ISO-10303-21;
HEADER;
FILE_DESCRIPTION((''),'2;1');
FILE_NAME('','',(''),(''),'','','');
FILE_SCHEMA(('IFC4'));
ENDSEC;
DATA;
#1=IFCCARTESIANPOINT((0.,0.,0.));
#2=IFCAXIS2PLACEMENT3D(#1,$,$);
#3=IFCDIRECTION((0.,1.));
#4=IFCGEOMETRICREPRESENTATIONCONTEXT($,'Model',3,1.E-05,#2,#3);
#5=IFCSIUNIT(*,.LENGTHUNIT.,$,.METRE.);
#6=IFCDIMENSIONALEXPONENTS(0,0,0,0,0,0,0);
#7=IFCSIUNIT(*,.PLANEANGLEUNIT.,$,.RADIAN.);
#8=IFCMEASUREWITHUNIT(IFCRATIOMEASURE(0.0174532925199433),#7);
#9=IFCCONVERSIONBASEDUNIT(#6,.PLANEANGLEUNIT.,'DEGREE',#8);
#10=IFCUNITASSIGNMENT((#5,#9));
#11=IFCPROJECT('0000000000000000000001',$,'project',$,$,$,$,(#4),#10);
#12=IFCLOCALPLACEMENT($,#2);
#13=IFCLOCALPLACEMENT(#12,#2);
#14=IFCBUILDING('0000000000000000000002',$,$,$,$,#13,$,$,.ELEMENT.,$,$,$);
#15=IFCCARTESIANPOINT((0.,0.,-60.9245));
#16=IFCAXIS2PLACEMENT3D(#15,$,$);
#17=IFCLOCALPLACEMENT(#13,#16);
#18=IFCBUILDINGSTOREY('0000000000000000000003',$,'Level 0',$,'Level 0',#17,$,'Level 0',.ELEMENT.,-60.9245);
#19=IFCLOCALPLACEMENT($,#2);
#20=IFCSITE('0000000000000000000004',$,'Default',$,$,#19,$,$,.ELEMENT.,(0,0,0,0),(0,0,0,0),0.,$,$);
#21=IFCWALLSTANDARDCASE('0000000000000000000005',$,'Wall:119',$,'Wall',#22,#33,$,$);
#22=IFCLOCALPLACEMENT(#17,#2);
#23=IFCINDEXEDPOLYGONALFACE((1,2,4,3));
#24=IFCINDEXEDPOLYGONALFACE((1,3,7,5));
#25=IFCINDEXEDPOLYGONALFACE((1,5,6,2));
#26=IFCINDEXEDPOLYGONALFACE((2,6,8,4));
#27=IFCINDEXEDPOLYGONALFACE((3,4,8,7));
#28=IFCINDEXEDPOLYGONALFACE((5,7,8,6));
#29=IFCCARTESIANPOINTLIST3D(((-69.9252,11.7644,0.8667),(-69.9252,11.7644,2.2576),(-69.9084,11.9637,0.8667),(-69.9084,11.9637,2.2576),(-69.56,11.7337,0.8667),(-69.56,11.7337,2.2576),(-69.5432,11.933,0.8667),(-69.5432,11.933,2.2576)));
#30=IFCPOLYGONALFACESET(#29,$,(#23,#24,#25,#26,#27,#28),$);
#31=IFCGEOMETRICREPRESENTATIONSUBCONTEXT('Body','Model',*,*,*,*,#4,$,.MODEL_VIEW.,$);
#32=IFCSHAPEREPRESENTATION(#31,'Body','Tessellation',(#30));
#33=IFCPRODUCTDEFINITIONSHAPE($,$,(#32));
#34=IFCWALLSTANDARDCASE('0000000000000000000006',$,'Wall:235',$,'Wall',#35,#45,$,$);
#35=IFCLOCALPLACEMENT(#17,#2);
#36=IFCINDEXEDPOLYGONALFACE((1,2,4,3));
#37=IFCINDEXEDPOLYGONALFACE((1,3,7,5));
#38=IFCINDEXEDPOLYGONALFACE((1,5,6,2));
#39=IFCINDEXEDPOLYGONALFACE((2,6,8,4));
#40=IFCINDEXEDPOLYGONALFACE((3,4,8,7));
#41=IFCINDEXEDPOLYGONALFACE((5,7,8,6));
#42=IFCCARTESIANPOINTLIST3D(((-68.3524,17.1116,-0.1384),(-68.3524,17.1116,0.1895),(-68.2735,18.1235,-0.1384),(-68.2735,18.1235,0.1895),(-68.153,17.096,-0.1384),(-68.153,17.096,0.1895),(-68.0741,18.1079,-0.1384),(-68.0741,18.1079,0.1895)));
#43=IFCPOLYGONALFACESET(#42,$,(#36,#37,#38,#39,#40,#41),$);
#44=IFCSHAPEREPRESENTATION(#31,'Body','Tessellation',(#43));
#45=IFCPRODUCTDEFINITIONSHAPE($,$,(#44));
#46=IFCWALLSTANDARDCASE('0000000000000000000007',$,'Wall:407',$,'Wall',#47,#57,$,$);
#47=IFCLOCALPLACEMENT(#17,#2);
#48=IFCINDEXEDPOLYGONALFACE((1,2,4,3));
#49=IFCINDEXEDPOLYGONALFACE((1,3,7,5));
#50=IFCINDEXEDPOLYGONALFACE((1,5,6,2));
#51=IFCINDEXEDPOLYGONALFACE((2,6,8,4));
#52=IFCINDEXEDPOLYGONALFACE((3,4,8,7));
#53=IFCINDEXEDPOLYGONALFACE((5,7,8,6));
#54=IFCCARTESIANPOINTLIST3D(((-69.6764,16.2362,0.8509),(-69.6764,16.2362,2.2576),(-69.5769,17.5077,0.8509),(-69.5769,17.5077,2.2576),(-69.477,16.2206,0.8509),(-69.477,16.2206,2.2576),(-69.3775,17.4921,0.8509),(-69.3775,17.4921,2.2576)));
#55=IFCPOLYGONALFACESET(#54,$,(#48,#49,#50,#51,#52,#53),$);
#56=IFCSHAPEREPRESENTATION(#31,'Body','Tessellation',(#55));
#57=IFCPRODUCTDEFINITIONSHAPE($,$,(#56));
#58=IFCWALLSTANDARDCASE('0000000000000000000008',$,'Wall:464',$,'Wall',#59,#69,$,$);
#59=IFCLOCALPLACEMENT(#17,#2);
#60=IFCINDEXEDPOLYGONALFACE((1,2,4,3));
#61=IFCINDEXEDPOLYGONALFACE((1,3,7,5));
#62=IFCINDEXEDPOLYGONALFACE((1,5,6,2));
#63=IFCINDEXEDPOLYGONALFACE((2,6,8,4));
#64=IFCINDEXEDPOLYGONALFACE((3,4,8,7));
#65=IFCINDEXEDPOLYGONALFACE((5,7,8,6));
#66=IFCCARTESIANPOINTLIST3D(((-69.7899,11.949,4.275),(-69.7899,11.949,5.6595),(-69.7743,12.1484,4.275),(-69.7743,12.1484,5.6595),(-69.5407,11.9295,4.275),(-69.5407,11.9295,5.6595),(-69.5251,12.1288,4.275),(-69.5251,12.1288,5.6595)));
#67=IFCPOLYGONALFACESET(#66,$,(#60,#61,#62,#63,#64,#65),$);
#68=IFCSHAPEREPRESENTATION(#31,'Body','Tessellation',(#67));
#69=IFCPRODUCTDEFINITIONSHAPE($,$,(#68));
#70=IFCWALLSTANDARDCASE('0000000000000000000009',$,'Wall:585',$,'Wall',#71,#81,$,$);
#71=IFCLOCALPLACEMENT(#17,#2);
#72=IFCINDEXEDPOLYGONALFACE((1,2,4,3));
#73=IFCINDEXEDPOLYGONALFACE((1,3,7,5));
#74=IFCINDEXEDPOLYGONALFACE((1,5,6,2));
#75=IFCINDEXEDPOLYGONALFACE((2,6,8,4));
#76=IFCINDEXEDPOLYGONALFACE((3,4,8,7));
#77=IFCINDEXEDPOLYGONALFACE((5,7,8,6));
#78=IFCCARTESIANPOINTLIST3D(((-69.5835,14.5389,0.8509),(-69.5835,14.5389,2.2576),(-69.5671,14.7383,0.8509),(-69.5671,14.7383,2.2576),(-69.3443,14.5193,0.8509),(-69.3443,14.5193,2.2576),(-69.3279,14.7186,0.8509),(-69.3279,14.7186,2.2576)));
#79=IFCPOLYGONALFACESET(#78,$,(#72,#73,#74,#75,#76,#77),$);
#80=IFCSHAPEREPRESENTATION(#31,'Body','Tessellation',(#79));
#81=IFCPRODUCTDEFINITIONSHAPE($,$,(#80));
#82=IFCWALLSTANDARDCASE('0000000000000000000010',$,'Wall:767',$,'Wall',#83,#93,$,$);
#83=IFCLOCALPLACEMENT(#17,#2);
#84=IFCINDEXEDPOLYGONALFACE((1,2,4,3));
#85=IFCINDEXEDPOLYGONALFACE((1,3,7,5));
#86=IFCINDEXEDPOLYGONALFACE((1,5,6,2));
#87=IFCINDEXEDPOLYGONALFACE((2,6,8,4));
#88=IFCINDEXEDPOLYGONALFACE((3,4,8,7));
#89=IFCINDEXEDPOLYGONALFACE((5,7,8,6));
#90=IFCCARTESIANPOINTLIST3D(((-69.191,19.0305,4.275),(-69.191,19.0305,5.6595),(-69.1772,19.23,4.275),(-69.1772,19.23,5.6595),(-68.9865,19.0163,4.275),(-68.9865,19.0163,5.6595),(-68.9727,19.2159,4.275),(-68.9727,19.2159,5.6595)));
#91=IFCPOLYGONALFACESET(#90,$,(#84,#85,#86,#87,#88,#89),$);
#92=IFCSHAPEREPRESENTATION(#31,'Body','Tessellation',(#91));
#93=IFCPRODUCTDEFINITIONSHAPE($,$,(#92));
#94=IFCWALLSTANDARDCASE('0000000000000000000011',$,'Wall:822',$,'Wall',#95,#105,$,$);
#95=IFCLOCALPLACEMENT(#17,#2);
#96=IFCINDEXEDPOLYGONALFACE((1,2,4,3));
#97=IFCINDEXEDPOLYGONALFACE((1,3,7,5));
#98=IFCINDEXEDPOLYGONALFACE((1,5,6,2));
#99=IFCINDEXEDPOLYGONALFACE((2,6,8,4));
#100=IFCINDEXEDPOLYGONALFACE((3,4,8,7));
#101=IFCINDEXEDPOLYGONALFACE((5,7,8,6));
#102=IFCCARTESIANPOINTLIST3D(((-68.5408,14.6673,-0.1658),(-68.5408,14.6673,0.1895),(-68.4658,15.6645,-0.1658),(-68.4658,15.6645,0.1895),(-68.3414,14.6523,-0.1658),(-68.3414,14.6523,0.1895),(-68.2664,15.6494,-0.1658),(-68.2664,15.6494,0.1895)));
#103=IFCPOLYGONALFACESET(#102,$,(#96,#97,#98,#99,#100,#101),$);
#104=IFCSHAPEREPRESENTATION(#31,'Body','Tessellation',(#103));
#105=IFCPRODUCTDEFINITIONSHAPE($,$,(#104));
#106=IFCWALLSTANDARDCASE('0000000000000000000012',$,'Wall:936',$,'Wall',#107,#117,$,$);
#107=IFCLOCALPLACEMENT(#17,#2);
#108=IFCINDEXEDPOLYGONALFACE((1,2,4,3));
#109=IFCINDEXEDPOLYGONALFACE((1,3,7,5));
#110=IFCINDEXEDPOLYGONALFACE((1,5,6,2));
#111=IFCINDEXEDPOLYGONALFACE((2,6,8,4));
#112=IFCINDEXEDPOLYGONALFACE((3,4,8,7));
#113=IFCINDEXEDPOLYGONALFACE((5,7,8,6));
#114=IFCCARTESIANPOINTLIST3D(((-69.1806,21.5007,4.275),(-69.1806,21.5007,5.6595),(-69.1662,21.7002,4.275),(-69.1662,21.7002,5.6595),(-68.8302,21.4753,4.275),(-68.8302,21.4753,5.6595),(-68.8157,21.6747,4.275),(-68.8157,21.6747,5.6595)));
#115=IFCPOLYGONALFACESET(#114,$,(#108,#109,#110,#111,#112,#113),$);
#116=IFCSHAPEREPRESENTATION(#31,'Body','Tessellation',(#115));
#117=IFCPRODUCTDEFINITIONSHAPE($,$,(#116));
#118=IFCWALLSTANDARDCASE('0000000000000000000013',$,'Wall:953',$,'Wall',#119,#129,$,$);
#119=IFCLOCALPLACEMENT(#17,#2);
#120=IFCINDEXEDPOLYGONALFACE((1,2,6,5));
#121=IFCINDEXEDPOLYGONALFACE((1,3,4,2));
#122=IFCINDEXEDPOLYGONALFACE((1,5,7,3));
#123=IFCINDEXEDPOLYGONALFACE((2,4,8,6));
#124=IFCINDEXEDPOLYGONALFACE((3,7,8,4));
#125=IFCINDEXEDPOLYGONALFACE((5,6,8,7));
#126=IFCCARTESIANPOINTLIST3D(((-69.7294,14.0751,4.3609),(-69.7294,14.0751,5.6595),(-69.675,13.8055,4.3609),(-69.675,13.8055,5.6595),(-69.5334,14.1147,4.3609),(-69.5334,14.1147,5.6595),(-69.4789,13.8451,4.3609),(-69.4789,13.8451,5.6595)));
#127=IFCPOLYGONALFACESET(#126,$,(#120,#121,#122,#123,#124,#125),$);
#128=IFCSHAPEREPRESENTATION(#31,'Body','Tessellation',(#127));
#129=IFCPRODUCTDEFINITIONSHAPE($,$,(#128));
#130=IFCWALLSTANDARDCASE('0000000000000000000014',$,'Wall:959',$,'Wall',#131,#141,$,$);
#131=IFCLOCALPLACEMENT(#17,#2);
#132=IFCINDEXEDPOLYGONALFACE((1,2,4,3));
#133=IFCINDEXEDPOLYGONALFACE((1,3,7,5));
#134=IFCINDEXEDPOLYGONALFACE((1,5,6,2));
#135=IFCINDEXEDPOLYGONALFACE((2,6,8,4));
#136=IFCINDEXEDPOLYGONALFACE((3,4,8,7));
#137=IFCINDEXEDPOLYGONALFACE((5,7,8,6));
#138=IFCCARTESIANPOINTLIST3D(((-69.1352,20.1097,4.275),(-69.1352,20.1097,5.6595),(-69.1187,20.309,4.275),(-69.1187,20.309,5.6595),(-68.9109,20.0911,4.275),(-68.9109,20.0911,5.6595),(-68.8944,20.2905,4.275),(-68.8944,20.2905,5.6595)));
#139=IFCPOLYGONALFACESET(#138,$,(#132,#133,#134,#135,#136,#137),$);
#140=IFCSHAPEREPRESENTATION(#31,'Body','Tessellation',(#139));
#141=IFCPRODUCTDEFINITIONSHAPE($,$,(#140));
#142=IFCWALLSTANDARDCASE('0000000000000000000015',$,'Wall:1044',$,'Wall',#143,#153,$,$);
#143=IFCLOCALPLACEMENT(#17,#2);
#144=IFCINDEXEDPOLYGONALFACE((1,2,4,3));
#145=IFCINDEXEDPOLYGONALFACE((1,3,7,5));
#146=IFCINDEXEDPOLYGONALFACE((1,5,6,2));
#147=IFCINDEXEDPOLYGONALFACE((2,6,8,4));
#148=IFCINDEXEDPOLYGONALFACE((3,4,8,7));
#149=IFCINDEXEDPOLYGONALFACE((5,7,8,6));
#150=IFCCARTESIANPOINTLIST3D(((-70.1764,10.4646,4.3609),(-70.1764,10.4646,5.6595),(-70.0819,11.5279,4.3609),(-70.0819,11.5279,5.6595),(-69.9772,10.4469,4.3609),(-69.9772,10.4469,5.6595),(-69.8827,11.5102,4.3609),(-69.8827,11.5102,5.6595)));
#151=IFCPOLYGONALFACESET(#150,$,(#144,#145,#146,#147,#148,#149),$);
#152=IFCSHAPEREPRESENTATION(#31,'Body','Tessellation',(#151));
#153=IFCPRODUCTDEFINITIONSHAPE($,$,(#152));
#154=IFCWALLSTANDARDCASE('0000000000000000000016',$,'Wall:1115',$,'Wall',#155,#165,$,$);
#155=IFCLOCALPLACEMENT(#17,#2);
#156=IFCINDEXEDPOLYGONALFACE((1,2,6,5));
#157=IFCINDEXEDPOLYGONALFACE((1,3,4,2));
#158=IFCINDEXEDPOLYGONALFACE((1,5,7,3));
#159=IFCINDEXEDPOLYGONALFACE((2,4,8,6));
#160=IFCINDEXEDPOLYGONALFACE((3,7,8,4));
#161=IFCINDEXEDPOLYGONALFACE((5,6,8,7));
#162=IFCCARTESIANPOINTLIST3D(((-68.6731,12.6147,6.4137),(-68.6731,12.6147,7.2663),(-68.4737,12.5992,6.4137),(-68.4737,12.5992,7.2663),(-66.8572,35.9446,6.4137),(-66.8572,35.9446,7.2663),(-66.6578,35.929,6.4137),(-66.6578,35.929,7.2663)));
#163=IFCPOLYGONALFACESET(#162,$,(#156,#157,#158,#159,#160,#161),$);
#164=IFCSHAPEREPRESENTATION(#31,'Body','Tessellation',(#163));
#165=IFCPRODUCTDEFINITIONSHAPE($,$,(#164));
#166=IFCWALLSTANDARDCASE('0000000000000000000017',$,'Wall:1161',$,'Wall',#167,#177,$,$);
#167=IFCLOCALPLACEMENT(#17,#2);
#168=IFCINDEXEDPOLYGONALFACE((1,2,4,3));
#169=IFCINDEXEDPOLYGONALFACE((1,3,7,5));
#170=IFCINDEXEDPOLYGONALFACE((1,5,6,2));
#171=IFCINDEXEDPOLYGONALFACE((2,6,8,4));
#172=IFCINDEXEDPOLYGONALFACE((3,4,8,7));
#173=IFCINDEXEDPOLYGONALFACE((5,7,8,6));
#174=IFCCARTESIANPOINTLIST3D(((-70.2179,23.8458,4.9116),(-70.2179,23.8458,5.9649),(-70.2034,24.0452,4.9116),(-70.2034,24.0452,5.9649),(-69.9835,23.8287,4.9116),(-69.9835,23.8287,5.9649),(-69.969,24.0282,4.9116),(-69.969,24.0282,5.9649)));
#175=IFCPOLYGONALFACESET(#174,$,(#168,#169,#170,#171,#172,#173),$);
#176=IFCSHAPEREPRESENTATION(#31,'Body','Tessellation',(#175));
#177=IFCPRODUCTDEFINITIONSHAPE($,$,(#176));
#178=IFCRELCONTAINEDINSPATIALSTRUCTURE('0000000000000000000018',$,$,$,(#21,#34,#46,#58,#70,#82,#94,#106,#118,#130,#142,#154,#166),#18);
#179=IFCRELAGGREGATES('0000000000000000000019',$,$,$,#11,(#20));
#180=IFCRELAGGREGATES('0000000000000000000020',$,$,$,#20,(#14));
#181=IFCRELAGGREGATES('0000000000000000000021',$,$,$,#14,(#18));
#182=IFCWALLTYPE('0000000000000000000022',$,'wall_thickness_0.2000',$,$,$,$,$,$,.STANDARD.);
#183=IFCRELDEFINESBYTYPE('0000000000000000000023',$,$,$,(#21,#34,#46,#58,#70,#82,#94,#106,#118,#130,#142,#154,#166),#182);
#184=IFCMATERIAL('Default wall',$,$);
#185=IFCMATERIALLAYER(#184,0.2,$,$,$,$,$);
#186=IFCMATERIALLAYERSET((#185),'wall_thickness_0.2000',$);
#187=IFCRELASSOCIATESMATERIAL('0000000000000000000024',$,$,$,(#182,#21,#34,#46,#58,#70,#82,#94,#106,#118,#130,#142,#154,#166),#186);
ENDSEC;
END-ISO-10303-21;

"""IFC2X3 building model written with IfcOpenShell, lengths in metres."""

from ifc_helpers import new_model, entity, si_unit, converted_unit, direction, frame, origin, place, context, subcontext, project, spatial, polyline, outline, extrude, material, layer, layer_set, layer_usage, type_object, element, save


model = new_model("IFC2X3")

# Units and contexts
model_context = context("Model", 3, precision=1e-05, world=origin(), true_north=direction((0.0, 1.0)))
body_context = subcontext(model_context, "Body", "Model", "MODEL_VIEW")
ifc_project = project(units=[si_unit("LENGTHUNIT", "METRE"), converted_unit("PLANEANGLEUNIT", "DEGREE", entity("IfcRatioMeasure", 0.0174532925199433), si_unit("PLANEANGLEUNIT", "RADIAN"), dimensions=[0, 0, 0, 0, 0, 0, 0])], contexts=[model_context])

# Site, building, storey
site_placement = place(None, origin())
site = spatial("IfcSite", under=ifc_project, at=site_placement, Name="Default", CompositionType="ELEMENT", RefLatitude=(0, 0, 0, 0), RefLongitude=(0, 0, 0, 0), RefElevation=0.0)
placement_1 = place(None, origin())
building_placement = place(placement_1, origin())
building = spatial("IfcBuilding", under=site, at=building_placement, CompositionType="ELEMENT")
storey_placement = place(building_placement, frame((0.0, 0.0, -60.9245)))
storey = spatial("IfcBuildingStorey", under=building, at=storey_placement, Name="Level 0", ObjectType="Level 0", LongName="Level 0", CompositionType="ELEMENT", Elevation=-60.9245)

# Walls
ifc_material = material(Name="Default wall")
ifc_layer = layer(ifc_material, 0.2)
ifc_layer_set = layer_set([ifc_layer], Name="wall_thickness_0.2000")
ifc_layer_usage = layer_usage(ifc_layer_set, "AXIS2", "POSITIVE", -0.1)
wall_type = type_object("IfcWallType", Name="wall_thickness_0.2000", PredefinedType="STANDARD", material=ifc_layer_set)
placement_2 = place(building_placement, frame((0.0, 0.0, -60.0578)))
wall_1_placement = place(placement_2, frame((-69.5516, 11.8333, 0.0), z_axis=(0.0, 0.0, 1.0), x_axis=(-0.996479, 0.083848, 0.0)))
element("IfcWallStandardCase", 1, at=wall_1_placement, inside=storey, type_object=wall_type, material=ifc_layer_usage, Name="Wall:119", ObjectType="Wall", context=body_context, shape_type="SweptSolid", body=[
    extrude(outline(polyline([(0.3665, -0.1), (0.3665, 0.1), (0.0, 0.1), (0.0, -0.1), (0.3665, -0.1)])), origin(), (0.0, 0.0, 1.0), 1.3909),
])
placement_3 = place(building_placement, frame((0.0, 0.0, -61.0629)))
wall_2_placement = place(placement_3, frame((-68.2527, 17.1038, 0.0), z_axis=(0.0, 0.0, 1.0), x_axis=(0.077737, 0.996974, 0.0)))
element("IfcWallStandardCase", 2, at=wall_2_placement, inside=storey, type_object=wall_type, material=ifc_layer_usage, Name="Wall:235", ObjectType="Wall", context=body_context, shape_type="SweptSolid", body=[
    extrude(outline(polyline([(1.015, -0.1), (1.015, 0.1), (0.0, 0.1), (0.0, -0.1), (1.015, -0.1)])), origin(), (0.0, 0.0, 1.0), 0.3279),
])
placement_4 = place(building_placement, frame((0.0, 0.0, -60.0736)))
wall_3_placement = place(placement_4, frame((-69.4772, 17.4999, 0.0), z_axis=(0.0, 0.0, 1.0), x_axis=(-0.078009, -0.996953, 0.0)))
element("IfcWallStandardCase", 3, at=wall_3_placement, inside=storey, type_object=wall_type, material=ifc_layer_usage, Name="Wall:407", ObjectType="Wall", context=body_context, shape_type="SweptSolid", body=[
    extrude(outline(polyline([(1.2754, -0.1), (1.2754, 0.1), (0.0, 0.1), (0.0, -0.1), (1.2754, -0.1)])), origin(), (0.0, 0.0, 1.0), 1.4068),
])
placement_5 = place(building_placement, frame((0.0, 0.0, -56.6495)))
wall_4_placement = place(placement_5, frame((-69.5329, 12.0291, 0.0), z_axis=(0.0, 0.0, 1.0), x_axis=(-0.996945, 0.078106, 0.0)))
element("IfcWallStandardCase", 4, at=wall_4_placement, inside=storey, type_object=wall_type, material=ifc_layer_usage, Name="Wall:464", ObjectType="Wall", context=body_context, shape_type="SweptSolid", body=[
    extrude(outline(polyline([(0.25, -0.1), (0.25, 0.1), (0.0, 0.1), (0.0, -0.1), (0.25, -0.1)])), origin(), (0.0, 0.0, 1.0), 1.3845),
])
placement_6 = place(building_placement, frame((0.0, 0.0, -60.0736)))
wall_5_placement = place(placement_6, frame((-69.3361, 14.6189, 0.0), z_axis=(0.0, 0.0, 1.0), x_axis=(-0.996635, 0.081969, 0.0)))
element("IfcWallStandardCase", 5, at=wall_5_placement, inside=storey, type_object=wall_type, material=ifc_layer_usage, Name="Wall:585", ObjectType="Wall", context=body_context, shape_type="SweptSolid", body=[
    extrude(outline(polyline([(0.24, -0.1), (0.24, 0.1), (0.0, 0.1), (0.0, -0.1), (0.24, -0.1)])), origin(), (0.0, 0.0, 1.0), 1.4068),
])
placement_7 = place(building_placement, frame((0.0, 0.0, -56.6495)))
wall_6_placement = place(placement_7, frame((-68.9796, 19.1161, 0.0), z_axis=(0.0, 0.0, 1.0), x_axis=(-0.997624, 0.068897, 0.0)))
element("IfcWallStandardCase", 6, at=wall_6_placement, inside=storey, type_object=wall_type, material=ifc_layer_usage, Name="Wall:767", ObjectType="Wall", context=body_context, shape_type="SweptSolid", body=[
    extrude(outline(polyline([(0.205, -0.1), (0.205, 0.1), (0.0, 0.1), (0.0, -0.1), (0.205, -0.1)])), origin(), (0.0, 0.0, 1.0), 1.3845),
])
placement_8 = place(building_placement, frame((0.0, 0.0, -61.0903)))
wall_7_placement = place(placement_8, frame((-68.4411, 14.6598, 0.0), z_axis=(0.0, 0.0, 1.0), x_axis=(0.075028, 0.997181, 0.0)))
element("IfcWallStandardCase", 7, at=wall_7_placement, inside=storey, type_object=wall_type, material=ifc_layer_usage, Name="Wall:822", ObjectType="Wall", context=body_context, shape_type="SweptSolid", body=[
    extrude(outline(polyline([(1.0, -0.1), (1.0, 0.1), (0.0, 0.1), (0.0, -0.1), (1.0, -0.1)])), origin(), (0.0, 0.0, 1.0), 0.3553),
])
placement_9 = place(building_placement, frame((0.0, 0.0, -56.6495)))
wall_8_placement = place(placement_9, frame((-68.8229, 21.575, 0.0), z_axis=(0.0, 0.0, 1.0), x_axis=(-0.997378, 0.072361, 0.0)))
element("IfcWallStandardCase", 8, at=wall_8_placement, inside=storey, type_object=wall_type, material=ifc_layer_usage, Name="Wall:936", ObjectType="Wall", context=body_context, shape_type="SweptSolid", body=[
    extrude(outline(polyline([(0.3514, -0.1), (0.3514, 0.1), (0.0, 0.1), (0.0, -0.1), (0.3514, -0.1)])), origin(), (0.0, 0.0, 1.0), 1.3845),
])
placement_10 = place(building_placement, frame((0.0, 0.0, -56.5636)))
wall_9_placement = place(placement_10, frame((-69.5769, 13.8253, 0.0), z_axis=(0.0, 0.0, 1.0), x_axis=(-0.197976, 0.980207, 0.0)))
element("IfcWallStandardCase", 9, at=wall_9_placement, inside=storey, type_object=wall_type, material=ifc_layer_usage, Name="Wall:953", ObjectType="Wall", context=body_context, shape_type="SweptSolid", body=[
    extrude(outline(polyline([(0.275, -0.1), (0.275, 0.1), (0.0, 0.1), (0.0, -0.1), (0.275, -0.1)])), origin(), (0.0, 0.0, 1.0), 1.2985),
])
placement_11 = place(building_placement, frame((0.0, 0.0, -56.6495)))
wall_10_placement = place(placement_11, frame((-68.9027, 20.1908, 0.0), z_axis=(0.0, 0.0, 1.0), x_axis=(-0.996588, 0.08254, 0.0)))
element("IfcWallStandardCase", 10, at=wall_10_placement, inside=storey, type_object=wall_type, material=ifc_layer_usage, Name="Wall:959", ObjectType="Wall", context=body_context, shape_type="SweptSolid", body=[
    extrude(outline(polyline([(0.225, -0.1), (0.225, 0.1), (0.0, 0.1), (0.0, -0.1), (0.225, -0.1)])), origin(), (0.0, 0.0, 1.0), 1.3845),
])
placement_12 = place(building_placement, frame((0.0, 0.0, -56.5636)))
wall_11_placement = place(placement_12, frame((-69.9823, 11.5191, 0.0), z_axis=(0.0, 0.0, 1.0), x_axis=(-0.088555, -0.996071, 0.0)))
element("IfcWallStandardCase", 11, at=wall_11_placement, inside=storey, type_object=wall_type, material=ifc_layer_usage, Name="Wall:1044", ObjectType="Wall", context=body_context, shape_type="SweptSolid", body=[
    extrude(outline(polyline([(1.0675, -0.1), (1.0675, 0.1), (0.0, 0.1), (0.0, -0.1), (1.0675, -0.1)])), origin(), (0.0, 0.0, 1.0), 1.2985),
])
placement_13 = place(building_placement, frame((0.0, 0.0, -54.5108)))
wall_12_placement = place(placement_13, frame((-68.5734, 12.607, 0.0), z_axis=(0.0, 0.0, 1.0), x_axis=(0.077602, 0.996984, 0.0)))
element("IfcWallStandardCase", 12, at=wall_12_placement, inside=storey, type_object=wall_type, material=ifc_layer_usage, Name="Wall:1115", ObjectType="Wall", context=body_context, shape_type="SweptSolid", body=[
    extrude(outline(polyline([(23.4004, -0.1), (23.4004, 0.1), (0.0, 0.1), (0.0, -0.1), (23.4004, -0.1)])), origin(), (0.0, 0.0, 1.0), 0.8526),
])
placement_14 = place(building_placement, frame((0.0, 0.0, -56.0129)))
wall_13_placement = place(placement_14, frame((-69.9763, 23.9284, 0.0), z_axis=(0.0, 0.0, 1.0), x_axis=(-0.997357, 0.072659, 0.0)))
element("IfcWallStandardCase", 13, at=wall_13_placement, inside=storey, type_object=wall_type, material=ifc_layer_usage, Name="Wall:1161", ObjectType="Wall", context=body_context, shape_type="SweptSolid", body=[
    extrude(outline(polyline([(0.235, -0.1), (0.235, 0.1), (0.0, 0.1), (0.0, -0.1), (0.235, -0.1)])), origin(), (0.0, 0.0, 1.0), 1.0533),
])

save(model, "model.ifc")
